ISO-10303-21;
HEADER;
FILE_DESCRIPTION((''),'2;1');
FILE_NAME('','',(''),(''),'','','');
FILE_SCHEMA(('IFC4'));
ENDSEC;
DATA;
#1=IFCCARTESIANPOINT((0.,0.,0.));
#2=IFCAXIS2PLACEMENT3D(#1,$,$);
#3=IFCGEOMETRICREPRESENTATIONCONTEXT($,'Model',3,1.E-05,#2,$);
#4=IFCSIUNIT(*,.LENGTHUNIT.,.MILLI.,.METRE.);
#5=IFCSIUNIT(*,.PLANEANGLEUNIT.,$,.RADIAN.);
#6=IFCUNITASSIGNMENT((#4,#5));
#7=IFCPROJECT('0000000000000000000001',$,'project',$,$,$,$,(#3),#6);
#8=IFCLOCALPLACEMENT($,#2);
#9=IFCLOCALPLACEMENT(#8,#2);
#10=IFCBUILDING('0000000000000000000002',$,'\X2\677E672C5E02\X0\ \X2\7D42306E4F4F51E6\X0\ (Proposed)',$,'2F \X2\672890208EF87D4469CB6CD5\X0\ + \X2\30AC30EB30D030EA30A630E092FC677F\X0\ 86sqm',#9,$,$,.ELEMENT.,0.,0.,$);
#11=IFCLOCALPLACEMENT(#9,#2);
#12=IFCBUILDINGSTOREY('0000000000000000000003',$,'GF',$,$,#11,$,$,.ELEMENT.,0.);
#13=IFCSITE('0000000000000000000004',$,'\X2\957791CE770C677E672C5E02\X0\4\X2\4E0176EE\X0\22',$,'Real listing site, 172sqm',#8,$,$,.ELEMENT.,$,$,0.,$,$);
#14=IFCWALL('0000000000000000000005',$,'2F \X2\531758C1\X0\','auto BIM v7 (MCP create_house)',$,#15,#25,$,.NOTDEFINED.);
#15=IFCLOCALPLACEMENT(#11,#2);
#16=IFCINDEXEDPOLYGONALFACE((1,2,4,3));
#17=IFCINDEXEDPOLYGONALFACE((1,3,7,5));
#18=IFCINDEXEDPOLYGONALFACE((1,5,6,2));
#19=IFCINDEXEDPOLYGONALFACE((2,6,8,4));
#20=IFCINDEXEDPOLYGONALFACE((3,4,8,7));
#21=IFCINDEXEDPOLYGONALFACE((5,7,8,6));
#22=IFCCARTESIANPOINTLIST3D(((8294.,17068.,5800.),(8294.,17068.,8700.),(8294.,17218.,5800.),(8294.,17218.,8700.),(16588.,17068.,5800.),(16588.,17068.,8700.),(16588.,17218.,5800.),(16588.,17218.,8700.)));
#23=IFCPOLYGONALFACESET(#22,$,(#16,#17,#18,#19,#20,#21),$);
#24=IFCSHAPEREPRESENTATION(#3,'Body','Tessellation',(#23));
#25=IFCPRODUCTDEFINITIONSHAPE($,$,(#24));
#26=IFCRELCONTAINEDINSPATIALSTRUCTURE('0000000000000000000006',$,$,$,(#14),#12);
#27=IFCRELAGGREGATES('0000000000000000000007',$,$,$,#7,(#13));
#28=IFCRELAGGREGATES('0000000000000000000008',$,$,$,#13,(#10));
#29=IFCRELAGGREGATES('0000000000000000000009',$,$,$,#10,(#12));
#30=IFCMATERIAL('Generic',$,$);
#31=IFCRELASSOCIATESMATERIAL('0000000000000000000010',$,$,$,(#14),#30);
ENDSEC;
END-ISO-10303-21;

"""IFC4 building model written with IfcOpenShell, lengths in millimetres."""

from ifc_helpers import new_model, si_unit, frame, frame_2d, origin, place, context, project, spatial, rectangle, extrude, material, element, save


model = new_model("IFC4")

# Units and contexts
model_context = context("Model", 3, precision=1e-05, world=origin())
ifc_project = project(units=[si_unit("LENGTHUNIT", "METRE", prefix="MILLI"), si_unit("PLANEANGLEUNIT", "RADIAN")], contexts=[model_context])

# Site, building, storey
site_placement = place(None, origin())
site = spatial("IfcSite", under=ifc_project, at=site_placement, Name="長野県松本市4丁目22", ObjectType="Real listing site, 172sqm", CompositionType="ELEMENT", RefElevation=0.0)
building_placement = place(site_placement, origin())
building = spatial("IfcBuilding", under=site, at=building_placement, Name="松本市 終の住処 (Proposed)", ObjectType="2F 木造軸組構法 + ガルバリウム鋼板 86sqm", CompositionType="ELEMENT", ElevationOfRefHeight=0.0, ElevationOfTerrain=0.0)
storey_placement = place(building_placement, origin())
storey = spatial("IfcBuildingStorey", under=building, at=storey_placement, Name="GF", CompositionType="ELEMENT", Elevation=0.0)

# Shared definitions
ifc_material = material(Name="Generic")

# Wall
wall_1_placement = place(storey_placement, frame((4147.0, 8534.0, 2900.0)))
element("IfcWall", 1, at=wall_1_placement, inside=storey, material=ifc_material, Name="2F 北壁", Description="auto BIM v7 (MCP create_house)", PredefinedType="NOTDEFINED", context=model_context, shape_type="SweptSolid", body=[
    extrude(rectangle(XDim=8294.0, YDim=150.0, at=frame_2d((4147.0, 75.0))), frame((4147.0, 8534.0, 2900.0)), (0.0, 0.0, 1.0), 2900.0),
])

save(model, "model.ifc")
